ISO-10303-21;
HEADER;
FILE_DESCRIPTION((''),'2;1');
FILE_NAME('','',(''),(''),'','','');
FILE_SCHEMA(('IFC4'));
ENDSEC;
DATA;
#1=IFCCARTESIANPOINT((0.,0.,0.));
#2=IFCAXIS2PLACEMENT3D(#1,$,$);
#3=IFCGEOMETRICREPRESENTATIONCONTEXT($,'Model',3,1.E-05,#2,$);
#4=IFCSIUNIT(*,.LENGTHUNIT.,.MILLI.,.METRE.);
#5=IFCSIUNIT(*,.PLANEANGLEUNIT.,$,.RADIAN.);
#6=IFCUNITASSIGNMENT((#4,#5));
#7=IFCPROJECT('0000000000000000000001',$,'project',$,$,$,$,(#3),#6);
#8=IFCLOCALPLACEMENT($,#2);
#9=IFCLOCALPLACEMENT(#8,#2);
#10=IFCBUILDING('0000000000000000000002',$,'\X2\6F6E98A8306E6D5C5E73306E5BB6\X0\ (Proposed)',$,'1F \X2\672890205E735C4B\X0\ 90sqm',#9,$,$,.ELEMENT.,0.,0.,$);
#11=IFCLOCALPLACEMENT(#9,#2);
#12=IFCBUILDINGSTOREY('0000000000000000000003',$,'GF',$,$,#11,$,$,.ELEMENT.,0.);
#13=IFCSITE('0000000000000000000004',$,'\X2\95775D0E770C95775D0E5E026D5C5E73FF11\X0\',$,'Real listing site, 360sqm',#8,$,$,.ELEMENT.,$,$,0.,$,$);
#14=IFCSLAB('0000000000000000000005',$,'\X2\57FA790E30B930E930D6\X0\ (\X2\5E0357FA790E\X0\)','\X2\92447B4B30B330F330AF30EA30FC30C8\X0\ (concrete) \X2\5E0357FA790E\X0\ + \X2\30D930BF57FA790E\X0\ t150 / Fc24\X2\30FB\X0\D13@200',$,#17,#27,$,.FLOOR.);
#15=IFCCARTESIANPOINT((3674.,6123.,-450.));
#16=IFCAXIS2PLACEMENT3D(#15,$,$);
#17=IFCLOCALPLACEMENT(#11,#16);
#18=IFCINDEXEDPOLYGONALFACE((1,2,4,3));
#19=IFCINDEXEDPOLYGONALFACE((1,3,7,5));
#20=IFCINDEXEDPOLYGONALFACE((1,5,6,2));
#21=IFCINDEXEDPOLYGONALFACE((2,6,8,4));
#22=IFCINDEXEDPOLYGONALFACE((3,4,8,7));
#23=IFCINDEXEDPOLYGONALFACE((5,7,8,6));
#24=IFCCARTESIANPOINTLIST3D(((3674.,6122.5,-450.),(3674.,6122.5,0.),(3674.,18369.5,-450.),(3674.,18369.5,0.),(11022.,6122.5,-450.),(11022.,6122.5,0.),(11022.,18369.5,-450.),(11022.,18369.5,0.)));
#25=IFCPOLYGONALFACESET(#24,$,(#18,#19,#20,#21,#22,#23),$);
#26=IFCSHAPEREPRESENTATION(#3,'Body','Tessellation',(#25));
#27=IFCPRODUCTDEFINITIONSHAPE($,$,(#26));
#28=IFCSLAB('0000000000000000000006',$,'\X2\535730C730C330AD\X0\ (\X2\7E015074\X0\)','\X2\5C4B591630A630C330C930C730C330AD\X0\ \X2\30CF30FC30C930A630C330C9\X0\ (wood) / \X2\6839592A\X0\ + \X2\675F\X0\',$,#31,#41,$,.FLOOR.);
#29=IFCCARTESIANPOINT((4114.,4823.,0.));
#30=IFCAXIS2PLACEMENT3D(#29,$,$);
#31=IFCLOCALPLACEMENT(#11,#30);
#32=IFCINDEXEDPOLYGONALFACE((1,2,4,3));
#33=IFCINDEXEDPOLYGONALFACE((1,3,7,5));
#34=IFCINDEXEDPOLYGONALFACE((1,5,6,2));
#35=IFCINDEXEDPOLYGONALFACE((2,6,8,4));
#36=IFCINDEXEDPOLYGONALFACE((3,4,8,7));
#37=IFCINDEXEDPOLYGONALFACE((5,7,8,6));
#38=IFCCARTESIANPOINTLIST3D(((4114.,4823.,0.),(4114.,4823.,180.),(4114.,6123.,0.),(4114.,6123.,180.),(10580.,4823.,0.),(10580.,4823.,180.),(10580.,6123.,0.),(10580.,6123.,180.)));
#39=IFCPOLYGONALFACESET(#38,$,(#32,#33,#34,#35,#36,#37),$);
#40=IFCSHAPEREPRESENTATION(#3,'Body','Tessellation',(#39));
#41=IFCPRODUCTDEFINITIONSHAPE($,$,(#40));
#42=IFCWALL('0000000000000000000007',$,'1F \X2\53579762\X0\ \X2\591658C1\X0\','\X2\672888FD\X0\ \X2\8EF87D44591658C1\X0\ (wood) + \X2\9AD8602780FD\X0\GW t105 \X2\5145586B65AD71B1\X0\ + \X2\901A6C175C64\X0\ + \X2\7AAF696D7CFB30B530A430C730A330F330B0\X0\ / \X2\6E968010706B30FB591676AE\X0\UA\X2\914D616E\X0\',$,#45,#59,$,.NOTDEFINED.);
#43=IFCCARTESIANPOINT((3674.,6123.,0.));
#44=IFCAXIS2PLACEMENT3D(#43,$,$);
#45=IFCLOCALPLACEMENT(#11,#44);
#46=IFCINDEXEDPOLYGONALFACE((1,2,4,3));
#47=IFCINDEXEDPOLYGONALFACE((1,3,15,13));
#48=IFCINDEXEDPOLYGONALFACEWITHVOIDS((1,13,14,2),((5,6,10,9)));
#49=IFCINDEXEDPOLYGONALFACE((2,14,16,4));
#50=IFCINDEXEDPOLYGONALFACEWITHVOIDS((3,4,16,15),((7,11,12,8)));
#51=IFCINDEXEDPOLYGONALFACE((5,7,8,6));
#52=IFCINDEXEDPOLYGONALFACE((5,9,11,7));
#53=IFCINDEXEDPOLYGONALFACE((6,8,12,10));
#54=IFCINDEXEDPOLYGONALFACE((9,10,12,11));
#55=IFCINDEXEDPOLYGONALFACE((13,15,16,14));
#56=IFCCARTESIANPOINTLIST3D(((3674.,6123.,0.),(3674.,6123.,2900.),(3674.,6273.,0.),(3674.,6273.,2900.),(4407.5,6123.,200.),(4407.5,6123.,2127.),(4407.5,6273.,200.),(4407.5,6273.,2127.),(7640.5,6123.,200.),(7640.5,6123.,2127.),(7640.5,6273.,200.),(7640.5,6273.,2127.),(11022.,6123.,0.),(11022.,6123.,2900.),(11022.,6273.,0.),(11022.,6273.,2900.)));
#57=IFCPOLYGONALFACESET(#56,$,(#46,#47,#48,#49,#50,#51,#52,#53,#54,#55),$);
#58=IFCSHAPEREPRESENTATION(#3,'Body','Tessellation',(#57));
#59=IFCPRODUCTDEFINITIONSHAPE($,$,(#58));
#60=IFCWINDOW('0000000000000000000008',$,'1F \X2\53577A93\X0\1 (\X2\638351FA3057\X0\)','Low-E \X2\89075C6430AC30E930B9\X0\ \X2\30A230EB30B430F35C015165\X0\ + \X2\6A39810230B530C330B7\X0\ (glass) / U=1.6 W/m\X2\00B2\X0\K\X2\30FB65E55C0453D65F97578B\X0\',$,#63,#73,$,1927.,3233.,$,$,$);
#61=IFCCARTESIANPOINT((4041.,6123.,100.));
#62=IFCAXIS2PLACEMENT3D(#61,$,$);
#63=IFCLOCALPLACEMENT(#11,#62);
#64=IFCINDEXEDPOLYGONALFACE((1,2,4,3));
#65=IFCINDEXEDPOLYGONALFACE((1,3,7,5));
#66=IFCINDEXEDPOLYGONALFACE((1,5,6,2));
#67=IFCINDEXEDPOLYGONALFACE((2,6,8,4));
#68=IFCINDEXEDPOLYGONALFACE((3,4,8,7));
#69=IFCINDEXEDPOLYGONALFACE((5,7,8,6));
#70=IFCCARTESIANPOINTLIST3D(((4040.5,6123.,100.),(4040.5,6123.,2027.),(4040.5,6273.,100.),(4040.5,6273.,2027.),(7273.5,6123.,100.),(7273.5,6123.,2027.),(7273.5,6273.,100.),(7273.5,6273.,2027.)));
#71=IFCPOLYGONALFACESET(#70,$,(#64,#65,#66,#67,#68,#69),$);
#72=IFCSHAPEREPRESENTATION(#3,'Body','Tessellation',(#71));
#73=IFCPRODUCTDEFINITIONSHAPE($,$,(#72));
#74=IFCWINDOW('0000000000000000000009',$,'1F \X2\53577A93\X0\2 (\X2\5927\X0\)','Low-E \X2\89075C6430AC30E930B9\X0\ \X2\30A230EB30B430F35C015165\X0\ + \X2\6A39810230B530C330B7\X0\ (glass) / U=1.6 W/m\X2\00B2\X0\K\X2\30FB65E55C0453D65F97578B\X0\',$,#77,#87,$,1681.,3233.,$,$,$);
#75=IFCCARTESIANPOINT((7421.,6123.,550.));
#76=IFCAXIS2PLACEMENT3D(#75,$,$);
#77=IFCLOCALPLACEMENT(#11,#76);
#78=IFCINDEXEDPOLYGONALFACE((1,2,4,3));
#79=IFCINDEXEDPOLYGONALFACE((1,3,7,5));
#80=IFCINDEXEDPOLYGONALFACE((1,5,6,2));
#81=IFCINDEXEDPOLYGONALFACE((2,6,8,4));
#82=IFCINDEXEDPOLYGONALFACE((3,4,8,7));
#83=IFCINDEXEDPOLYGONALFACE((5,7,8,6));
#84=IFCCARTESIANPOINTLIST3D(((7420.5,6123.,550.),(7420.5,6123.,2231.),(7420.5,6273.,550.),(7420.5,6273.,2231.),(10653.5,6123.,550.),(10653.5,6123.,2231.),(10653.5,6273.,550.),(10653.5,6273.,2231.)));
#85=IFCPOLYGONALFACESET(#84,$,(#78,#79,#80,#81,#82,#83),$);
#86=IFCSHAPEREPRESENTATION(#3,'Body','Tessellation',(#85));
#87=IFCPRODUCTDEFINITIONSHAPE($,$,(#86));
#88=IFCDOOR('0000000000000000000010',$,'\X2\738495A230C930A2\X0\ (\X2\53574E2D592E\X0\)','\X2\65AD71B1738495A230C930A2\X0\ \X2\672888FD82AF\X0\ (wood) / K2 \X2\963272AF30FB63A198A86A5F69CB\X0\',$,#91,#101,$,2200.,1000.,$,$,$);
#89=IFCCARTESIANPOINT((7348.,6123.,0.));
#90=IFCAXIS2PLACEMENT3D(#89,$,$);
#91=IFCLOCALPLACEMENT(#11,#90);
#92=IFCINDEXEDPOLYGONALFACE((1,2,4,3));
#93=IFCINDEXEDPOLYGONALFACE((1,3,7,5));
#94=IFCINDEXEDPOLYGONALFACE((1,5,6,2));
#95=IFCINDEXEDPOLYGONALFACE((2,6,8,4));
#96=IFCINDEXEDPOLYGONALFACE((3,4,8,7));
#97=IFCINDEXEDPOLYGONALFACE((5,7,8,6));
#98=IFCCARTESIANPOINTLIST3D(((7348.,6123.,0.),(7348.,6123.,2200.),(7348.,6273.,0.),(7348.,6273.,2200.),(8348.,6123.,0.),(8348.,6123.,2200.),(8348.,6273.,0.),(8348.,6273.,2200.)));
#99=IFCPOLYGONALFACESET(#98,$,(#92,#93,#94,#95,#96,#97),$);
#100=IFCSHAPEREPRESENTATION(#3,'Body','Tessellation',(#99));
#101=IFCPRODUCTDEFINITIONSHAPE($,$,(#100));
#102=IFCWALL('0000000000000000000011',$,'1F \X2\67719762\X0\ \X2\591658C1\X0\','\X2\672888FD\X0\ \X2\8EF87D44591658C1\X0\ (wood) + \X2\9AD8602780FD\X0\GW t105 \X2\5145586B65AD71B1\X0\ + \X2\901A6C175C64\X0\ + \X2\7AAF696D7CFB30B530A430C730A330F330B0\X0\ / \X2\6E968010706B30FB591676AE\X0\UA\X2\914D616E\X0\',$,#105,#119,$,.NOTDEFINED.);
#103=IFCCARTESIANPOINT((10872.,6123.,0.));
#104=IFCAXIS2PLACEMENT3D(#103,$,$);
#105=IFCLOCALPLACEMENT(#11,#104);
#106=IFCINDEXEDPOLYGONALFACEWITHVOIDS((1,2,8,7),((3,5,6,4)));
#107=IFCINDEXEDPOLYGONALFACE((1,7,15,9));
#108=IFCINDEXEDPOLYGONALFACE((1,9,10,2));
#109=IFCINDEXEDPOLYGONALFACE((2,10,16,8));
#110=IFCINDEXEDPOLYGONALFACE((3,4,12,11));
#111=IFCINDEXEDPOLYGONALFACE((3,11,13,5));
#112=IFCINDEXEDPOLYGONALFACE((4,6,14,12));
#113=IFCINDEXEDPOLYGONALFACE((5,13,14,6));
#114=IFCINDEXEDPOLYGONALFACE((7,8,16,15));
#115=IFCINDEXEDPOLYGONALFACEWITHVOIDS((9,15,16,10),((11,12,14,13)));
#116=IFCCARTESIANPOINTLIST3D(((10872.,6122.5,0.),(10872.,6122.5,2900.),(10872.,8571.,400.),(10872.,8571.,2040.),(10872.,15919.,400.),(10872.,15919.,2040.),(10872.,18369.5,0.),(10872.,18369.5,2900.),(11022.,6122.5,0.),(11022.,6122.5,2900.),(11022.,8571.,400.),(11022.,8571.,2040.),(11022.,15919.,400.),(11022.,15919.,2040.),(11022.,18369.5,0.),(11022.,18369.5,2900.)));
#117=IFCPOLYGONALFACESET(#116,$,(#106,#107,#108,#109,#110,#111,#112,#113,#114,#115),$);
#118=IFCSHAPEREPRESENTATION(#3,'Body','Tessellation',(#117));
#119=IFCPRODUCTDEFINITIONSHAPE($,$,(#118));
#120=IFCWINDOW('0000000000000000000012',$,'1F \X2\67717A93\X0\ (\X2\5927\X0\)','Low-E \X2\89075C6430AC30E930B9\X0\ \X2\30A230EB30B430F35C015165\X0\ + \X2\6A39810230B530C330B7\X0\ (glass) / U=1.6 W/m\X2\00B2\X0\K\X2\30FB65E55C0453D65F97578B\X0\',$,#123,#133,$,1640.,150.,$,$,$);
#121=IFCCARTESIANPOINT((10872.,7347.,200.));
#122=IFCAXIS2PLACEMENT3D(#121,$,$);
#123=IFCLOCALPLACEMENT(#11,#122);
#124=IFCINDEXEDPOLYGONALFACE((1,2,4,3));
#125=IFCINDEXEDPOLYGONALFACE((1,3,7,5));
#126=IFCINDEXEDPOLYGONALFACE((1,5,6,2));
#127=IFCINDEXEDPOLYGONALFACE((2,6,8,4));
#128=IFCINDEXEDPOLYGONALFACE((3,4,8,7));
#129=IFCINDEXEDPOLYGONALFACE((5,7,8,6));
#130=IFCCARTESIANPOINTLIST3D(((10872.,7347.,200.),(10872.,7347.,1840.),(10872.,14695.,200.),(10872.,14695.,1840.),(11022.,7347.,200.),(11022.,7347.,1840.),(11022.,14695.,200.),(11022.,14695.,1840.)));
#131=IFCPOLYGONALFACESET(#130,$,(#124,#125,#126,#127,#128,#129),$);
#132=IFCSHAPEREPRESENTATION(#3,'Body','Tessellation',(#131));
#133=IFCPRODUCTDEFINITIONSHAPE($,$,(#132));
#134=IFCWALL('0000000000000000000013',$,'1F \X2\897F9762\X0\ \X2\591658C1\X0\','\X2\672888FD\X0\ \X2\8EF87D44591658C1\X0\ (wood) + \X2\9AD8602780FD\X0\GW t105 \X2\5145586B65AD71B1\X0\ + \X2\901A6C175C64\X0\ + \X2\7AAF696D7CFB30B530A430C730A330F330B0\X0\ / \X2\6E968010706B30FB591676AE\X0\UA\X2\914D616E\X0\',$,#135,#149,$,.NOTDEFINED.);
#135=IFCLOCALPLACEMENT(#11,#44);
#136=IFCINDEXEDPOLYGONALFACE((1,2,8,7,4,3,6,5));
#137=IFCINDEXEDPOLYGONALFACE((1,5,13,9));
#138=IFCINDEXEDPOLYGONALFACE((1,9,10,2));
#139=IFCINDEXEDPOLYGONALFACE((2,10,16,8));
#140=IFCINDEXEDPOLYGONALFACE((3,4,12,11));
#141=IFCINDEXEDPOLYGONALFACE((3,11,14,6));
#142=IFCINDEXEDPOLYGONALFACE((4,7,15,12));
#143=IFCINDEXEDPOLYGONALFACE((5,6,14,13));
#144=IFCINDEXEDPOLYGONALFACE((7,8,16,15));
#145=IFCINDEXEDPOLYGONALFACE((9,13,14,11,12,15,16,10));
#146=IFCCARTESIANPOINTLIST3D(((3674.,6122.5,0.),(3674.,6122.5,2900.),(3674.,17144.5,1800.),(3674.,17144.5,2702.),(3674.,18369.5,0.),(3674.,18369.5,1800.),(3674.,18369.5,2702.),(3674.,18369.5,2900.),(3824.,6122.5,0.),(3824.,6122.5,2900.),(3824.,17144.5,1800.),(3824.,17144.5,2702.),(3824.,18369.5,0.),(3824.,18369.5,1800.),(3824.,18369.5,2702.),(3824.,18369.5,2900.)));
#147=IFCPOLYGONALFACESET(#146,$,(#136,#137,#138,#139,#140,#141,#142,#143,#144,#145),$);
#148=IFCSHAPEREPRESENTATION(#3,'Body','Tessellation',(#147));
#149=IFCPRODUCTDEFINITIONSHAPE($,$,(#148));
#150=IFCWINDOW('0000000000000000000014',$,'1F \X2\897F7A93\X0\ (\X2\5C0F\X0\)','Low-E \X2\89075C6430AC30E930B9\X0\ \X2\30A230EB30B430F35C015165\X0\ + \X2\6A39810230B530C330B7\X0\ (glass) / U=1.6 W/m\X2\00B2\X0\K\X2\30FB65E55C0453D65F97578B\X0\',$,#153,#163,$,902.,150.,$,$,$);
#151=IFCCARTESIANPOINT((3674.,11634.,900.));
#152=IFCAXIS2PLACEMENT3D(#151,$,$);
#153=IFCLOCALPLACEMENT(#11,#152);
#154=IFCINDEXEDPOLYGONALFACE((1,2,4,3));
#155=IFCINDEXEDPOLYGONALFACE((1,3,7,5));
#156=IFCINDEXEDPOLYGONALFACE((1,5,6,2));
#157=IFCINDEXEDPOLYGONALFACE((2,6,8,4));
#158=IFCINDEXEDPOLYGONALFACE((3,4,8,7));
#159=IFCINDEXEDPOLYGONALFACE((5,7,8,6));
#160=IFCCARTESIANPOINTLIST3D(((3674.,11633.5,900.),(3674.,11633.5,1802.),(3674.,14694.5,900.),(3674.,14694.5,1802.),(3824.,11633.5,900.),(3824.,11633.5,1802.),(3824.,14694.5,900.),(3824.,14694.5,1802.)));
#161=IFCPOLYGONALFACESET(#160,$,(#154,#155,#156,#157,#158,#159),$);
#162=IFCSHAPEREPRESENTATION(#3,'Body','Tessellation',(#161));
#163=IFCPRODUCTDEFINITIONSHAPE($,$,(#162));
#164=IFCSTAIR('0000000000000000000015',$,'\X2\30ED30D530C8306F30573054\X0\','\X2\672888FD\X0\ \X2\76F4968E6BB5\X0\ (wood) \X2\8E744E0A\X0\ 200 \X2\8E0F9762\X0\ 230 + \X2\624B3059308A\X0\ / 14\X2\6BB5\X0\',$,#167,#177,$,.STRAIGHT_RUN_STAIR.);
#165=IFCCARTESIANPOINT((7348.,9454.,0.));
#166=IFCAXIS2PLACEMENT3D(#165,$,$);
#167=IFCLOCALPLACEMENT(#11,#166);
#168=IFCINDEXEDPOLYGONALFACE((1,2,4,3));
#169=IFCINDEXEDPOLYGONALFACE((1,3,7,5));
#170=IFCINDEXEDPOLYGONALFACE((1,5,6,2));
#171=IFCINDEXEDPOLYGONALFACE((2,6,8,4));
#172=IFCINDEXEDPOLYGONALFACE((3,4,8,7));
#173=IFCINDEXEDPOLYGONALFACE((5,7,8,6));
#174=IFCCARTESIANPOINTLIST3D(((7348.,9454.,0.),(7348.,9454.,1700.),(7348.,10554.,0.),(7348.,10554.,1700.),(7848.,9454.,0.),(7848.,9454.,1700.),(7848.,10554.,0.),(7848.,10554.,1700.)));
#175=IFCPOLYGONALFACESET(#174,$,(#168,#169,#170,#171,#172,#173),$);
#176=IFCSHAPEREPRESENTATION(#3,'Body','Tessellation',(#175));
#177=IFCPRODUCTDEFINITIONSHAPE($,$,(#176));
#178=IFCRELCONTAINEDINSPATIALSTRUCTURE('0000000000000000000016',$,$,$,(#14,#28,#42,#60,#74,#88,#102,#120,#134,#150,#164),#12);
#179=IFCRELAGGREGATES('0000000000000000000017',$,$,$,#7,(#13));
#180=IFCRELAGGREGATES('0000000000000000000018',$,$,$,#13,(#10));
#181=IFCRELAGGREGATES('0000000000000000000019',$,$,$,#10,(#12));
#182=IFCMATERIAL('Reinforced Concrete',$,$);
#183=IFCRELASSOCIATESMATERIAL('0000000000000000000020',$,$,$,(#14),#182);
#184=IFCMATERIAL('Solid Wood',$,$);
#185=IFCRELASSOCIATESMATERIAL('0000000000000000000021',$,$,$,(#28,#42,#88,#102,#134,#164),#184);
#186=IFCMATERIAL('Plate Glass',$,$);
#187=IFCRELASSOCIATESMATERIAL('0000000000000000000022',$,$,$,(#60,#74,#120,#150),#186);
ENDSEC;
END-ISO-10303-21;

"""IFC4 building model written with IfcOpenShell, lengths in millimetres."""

from ifc_helpers import new_model, si_unit, frame, frame_2d, origin, place, context, project, spatial, rectangle, extrude, material, element, fill, save


model = new_model("IFC4")

# Units and contexts
model_context = context("Model", 3, precision=1e-05, world=origin())
ifc_project = project(units=[si_unit("LENGTHUNIT", "METRE", prefix="MILLI"), si_unit("PLANEANGLEUNIT", "RADIAN")], contexts=[model_context])

# Site, building, storey
site_placement = place(None, origin())
site = spatial("IfcSite", under=ifc_project, at=site_placement, Name="長崎県長崎市浜平１", ObjectType="Real listing site, 360sqm", CompositionType="ELEMENT", RefElevation=0.0)
building_placement = place(site_placement, origin())
building = spatial("IfcBuilding", under=site, at=building_placement, Name="潮風の浜平の家 (Proposed)", ObjectType="1F 木造平屋 90sqm", CompositionType="ELEMENT", ElevationOfRefHeight=0.0, ElevationOfTerrain=0.0)
storey_placement = place(building_placement, origin())
storey = spatial("IfcBuildingStorey", under=building, at=storey_placement, Name="GF", CompositionType="ELEMENT", Elevation=0.0)

# Slabs
ifc_material_1 = material(Name="Reinforced Concrete")
slab_1_placement = place(storey_placement, frame((3674.0, 6123.0, -450.0)))
element("IfcSlab", 1, at=slab_1_placement, inside=storey, material=ifc_material_1, Name="基礎スラブ (布基礎)", Description="鉄筋コンクリート (concrete) 布基礎 + ベタ基礎 t150 / Fc24・D13@200", PredefinedType="FLOOR", context=model_context, shape_type="SweptSolid", body=[
    extrude(rectangle(XDim=7348.0, YDim=12247.0, at=frame_2d((3674.0, 6123.0))), frame((3674.0, 6123.0, -450.0)), (0.0, 0.0, 1.0), 450.0),
])
ifc_material_2 = material(Name="Solid Wood")
slab_2_placement = place(storey_placement, frame((4114.0, 4823.0, 0.0)))
element("IfcSlab", 2, at=slab_2_placement, inside=storey, material=ifc_material_2, Name="南デッキ (縁側)", Description="屋外ウッドデッキ ハードウッド (wood) / 根太 + 束", PredefinedType="FLOOR", context=model_context, shape_type="SweptSolid", body=[
    extrude(rectangle(XDim=6466.0, YDim=1300.0, at=frame_2d((3233.0, 650.0))), frame((4114.0, 4823.0, 0.0)), (0.0, 0.0, 1.0), 180.0),
])

# Wall, openings, windows, door
wall_1_placement = place(storey_placement, frame((3674.0, 6123.0, 0.0)))
wall_1 = element("IfcWall", 3, at=wall_1_placement, inside=storey, material=ifc_material_2, Name="1F 南面 外壁", Description="木製 軸組外壁 (wood) + 高性能GW t105 充填断熱 + 通気層 + 窯業系サイディング / 準耐火・外皮UA配慮", PredefinedType="NOTDEFINED", context=model_context, shape_type="SweptSolid", body=[
    extrude(rectangle(XDim=7348.0, YDim=150.0, at=frame_2d((3674.0, 75.0))), frame((3674.0, 6123.0, 0.0)), (0.0, 0.0, 1.0), 2900.0),
])
opening_1_placement = place(storey_placement, frame((4041.0, 6123.0, 100.0)))
opening_1 = element("IfcOpeningElement", 4, at=opening_1_placement, cuts=wall_1, PredefinedType="NOTDEFINED", context=model_context, shape_type="SweptSolid", body=[
    extrude(rectangle(XDim=3233.0, YDim=150.0, at=frame_2d((1616.0, 75.0))), frame((4041.0, 6123.0, 100.0)), (0.0, 0.0, 1.0), 1927.0),
])
opening_2_placement = place(storey_placement, frame((7421.0, 6123.0, 550.0)))
opening_2 = element("IfcOpeningElement", 5, at=opening_2_placement, cuts=wall_1, PredefinedType="NOTDEFINED", context=model_context, shape_type="SweptSolid", body=[
    extrude(rectangle(XDim=3233.0, YDim=150.0, at=frame_2d((1616.0, 75.0))), frame((7421.0, 6123.0, 550.0)), (0.0, 0.0, 1.0), 1681.0),
])
opening_3_placement = place(storey_placement, frame((7348.0, 6123.0, 0.0)))
opening_3 = element("IfcOpeningElement", 6, at=opening_3_placement, cuts=wall_1, PredefinedType="NOTDEFINED", context=model_context, shape_type="SweptSolid", body=[
    extrude(rectangle(XDim=1000.0, YDim=150.0, at=frame_2d((500.0, 75.0))), frame((7348.0, 6123.0, 0.0)), (0.0, 0.0, 1.0), 2200.0),
])
ifc_material_3 = material(Name="Plate Glass")
window_1_placement = place(storey_placement, frame((4041.0, 6123.0, 100.0)))
window_1 = element("IfcWindow", 7, at=window_1_placement, inside=storey, material=ifc_material_3, Name="1F 南窓1 (掃出し)", Description="Low-E 複層ガラス アルゴン封入 + 樹脂サッシ (glass) / U=1.6 W/m²K・日射取得型", OverallHeight=1927.0, OverallWidth=3233.0, context=model_context, shape_type="SweptSolid", body=[
    extrude(rectangle(XDim=3233.0, YDim=150.0, at=frame_2d((1616.0, 75.0))), frame((4041.0, 6123.0, 100.0)), (0.0, 0.0, 1.0), 1927.0),
])
fill(opening_1, window_1)
window_2_placement = place(storey_placement, frame((7421.0, 6123.0, 550.0)))
window_2 = element("IfcWindow", 8, at=window_2_placement, inside=storey, material=ifc_material_3, Name="1F 南窓2 (大)", Description="Low-E 複層ガラス アルゴン封入 + 樹脂サッシ (glass) / U=1.6 W/m²K・日射取得型", OverallHeight=1681.0, OverallWidth=3233.0, context=model_context, shape_type="SweptSolid", body=[
    extrude(rectangle(XDim=3233.0, YDim=150.0, at=frame_2d((1616.0, 75.0))), frame((7421.0, 6123.0, 550.0)), (0.0, 0.0, 1.0), 1681.0),
])
fill(opening_2, window_2)
door_placement = place(storey_placement, frame((7348.0, 6123.0, 0.0)))
door = element("IfcDoor", 9, at=door_placement, inside=storey, material=ifc_material_2, Name="玄関ドア (南中央)", Description="断熱玄関ドア 木製芯 (wood) / K2 防犯・採風機構", OverallHeight=2200.0, OverallWidth=1000.0, context=model_context, shape_type="SweptSolid", body=[
    extrude(rectangle(XDim=1000.0, YDim=150.0, at=frame_2d((500.0, 75.0))), frame((7348.0, 6123.0, 0.0)), (0.0, 0.0, 1.0), 2200.0),
])
fill(opening_3, door)

# Walls, openings, windows
wall_2_placement = place(storey_placement, frame((10872.0, 6123.0, 0.0)))
wall_2 = element("IfcWall", 10, at=wall_2_placement, inside=storey, material=ifc_material_2, Name="1F 東面 外壁", Description="木製 軸組外壁 (wood) + 高性能GW t105 充填断熱 + 通気層 + 窯業系サイディング / 準耐火・外皮UA配慮", PredefinedType="NOTDEFINED", context=model_context, shape_type="SweptSolid", body=[
    extrude(rectangle(XDim=150.0, YDim=12247.0, at=frame_2d((75.0, 6123.0))), frame((10872.0, 6123.0, 0.0)), (0.0, 0.0, 1.0), 2900.0),
])
opening_4_placement = place(storey_placement, frame((10872.0, 7347.0, 200.0)))
opening_4 = element("IfcOpeningElement", 11, at=opening_4_placement, cuts=wall_2, PredefinedType="NOTDEFINED", context=model_context, shape_type="SweptSolid", body=[
    extrude(rectangle(XDim=150.0, YDim=7348.0, at=frame_2d((75.0, 3674.0))), frame((10872.0, 7347.0, 200.0)), (0.0, 0.0, 1.0), 1640.0),
])
window_3_placement = place(storey_placement, frame((10872.0, 7347.0, 200.0)))
window_3 = element("IfcWindow", 12, at=window_3_placement, inside=storey, material=ifc_material_3, Name="1F 東窓 (大)", Description="Low-E 複層ガラス アルゴン封入 + 樹脂サッシ (glass) / U=1.6 W/m²K・日射取得型", OverallHeight=1640.0, OverallWidth=150.0, context=model_context, shape_type="SweptSolid", body=[
    extrude(rectangle(XDim=150.0, YDim=7348.0, at=frame_2d((75.0, 3674.0))), frame((10872.0, 7347.0, 200.0)), (0.0, 0.0, 1.0), 1640.0),
])
fill(opening_4, window_3)
wall_3_placement = place(storey_placement, frame((3674.0, 6123.0, 0.0)))
wall_3 = element("IfcWall", 13, at=wall_3_placement, inside=storey, material=ifc_material_2, Name="1F 西面 外壁", Description="木製 軸組外壁 (wood) + 高性能GW t105 充填断熱 + 通気層 + 窯業系サイディング / 準耐火・外皮UA配慮", PredefinedType="NOTDEFINED", context=model_context, shape_type="SweptSolid", body=[
    extrude(rectangle(XDim=150.0, YDim=12247.0, at=frame_2d((75.0, 6123.0))), frame((3674.0, 6123.0, 0.0)), (0.0, 0.0, 1.0), 2900.0),
])
opening_5_placement = place(storey_placement, frame((3674.0, 11634.0, 900.0)))
opening_5 = element("IfcOpeningElement", 14, at=opening_5_placement, cuts=wall_3, PredefinedType="NOTDEFINED", context=model_context, shape_type="SweptSolid", body=[
    extrude(rectangle(XDim=150.0, YDim=3061.0, at=frame_2d((75.0, 1530.0))), frame((3674.0, 11634.0, 900.0)), (0.0, 0.0, 1.0), 902.0),
])
window_4_placement = place(storey_placement, frame((3674.0, 11634.0, 900.0)))
window_4 = element("IfcWindow", 15, at=window_4_placement, inside=storey, material=ifc_material_3, Name="1F 西窓 (小)", Description="Low-E 複層ガラス アルゴン封入 + 樹脂サッシ (glass) / U=1.6 W/m²K・日射取得型", OverallHeight=902.0, OverallWidth=150.0, context=model_context, shape_type="SweptSolid", body=[
    extrude(rectangle(XDim=150.0, YDim=3061.0, at=frame_2d((75.0, 1530.0))), frame((3674.0, 11634.0, 900.0)), (0.0, 0.0, 1.0), 902.0),
])
fill(opening_5, window_4)

# Stair
stair_placement = place(storey_placement, frame((7348.0, 9454.0, 0.0)))
element("IfcStair", 16, at=stair_placement, inside=storey, material=ifc_material_2, Name="ロフトはしご", Description="木製 直階段 (wood) 蹴上 200 踏面 230 + 手すり / 14段", PredefinedType="STRAIGHT_RUN_STAIR", context=model_context, shape_type="SweptSolid", body=[
    extrude(rectangle(XDim=500.0, YDim=1100.0, at=frame_2d((250.0, 550.0))), frame((7348.0, 9454.0, 0.0)), (0.0, 0.0, 1.0), 1700.0),
])

save(model, "model.ifc")
